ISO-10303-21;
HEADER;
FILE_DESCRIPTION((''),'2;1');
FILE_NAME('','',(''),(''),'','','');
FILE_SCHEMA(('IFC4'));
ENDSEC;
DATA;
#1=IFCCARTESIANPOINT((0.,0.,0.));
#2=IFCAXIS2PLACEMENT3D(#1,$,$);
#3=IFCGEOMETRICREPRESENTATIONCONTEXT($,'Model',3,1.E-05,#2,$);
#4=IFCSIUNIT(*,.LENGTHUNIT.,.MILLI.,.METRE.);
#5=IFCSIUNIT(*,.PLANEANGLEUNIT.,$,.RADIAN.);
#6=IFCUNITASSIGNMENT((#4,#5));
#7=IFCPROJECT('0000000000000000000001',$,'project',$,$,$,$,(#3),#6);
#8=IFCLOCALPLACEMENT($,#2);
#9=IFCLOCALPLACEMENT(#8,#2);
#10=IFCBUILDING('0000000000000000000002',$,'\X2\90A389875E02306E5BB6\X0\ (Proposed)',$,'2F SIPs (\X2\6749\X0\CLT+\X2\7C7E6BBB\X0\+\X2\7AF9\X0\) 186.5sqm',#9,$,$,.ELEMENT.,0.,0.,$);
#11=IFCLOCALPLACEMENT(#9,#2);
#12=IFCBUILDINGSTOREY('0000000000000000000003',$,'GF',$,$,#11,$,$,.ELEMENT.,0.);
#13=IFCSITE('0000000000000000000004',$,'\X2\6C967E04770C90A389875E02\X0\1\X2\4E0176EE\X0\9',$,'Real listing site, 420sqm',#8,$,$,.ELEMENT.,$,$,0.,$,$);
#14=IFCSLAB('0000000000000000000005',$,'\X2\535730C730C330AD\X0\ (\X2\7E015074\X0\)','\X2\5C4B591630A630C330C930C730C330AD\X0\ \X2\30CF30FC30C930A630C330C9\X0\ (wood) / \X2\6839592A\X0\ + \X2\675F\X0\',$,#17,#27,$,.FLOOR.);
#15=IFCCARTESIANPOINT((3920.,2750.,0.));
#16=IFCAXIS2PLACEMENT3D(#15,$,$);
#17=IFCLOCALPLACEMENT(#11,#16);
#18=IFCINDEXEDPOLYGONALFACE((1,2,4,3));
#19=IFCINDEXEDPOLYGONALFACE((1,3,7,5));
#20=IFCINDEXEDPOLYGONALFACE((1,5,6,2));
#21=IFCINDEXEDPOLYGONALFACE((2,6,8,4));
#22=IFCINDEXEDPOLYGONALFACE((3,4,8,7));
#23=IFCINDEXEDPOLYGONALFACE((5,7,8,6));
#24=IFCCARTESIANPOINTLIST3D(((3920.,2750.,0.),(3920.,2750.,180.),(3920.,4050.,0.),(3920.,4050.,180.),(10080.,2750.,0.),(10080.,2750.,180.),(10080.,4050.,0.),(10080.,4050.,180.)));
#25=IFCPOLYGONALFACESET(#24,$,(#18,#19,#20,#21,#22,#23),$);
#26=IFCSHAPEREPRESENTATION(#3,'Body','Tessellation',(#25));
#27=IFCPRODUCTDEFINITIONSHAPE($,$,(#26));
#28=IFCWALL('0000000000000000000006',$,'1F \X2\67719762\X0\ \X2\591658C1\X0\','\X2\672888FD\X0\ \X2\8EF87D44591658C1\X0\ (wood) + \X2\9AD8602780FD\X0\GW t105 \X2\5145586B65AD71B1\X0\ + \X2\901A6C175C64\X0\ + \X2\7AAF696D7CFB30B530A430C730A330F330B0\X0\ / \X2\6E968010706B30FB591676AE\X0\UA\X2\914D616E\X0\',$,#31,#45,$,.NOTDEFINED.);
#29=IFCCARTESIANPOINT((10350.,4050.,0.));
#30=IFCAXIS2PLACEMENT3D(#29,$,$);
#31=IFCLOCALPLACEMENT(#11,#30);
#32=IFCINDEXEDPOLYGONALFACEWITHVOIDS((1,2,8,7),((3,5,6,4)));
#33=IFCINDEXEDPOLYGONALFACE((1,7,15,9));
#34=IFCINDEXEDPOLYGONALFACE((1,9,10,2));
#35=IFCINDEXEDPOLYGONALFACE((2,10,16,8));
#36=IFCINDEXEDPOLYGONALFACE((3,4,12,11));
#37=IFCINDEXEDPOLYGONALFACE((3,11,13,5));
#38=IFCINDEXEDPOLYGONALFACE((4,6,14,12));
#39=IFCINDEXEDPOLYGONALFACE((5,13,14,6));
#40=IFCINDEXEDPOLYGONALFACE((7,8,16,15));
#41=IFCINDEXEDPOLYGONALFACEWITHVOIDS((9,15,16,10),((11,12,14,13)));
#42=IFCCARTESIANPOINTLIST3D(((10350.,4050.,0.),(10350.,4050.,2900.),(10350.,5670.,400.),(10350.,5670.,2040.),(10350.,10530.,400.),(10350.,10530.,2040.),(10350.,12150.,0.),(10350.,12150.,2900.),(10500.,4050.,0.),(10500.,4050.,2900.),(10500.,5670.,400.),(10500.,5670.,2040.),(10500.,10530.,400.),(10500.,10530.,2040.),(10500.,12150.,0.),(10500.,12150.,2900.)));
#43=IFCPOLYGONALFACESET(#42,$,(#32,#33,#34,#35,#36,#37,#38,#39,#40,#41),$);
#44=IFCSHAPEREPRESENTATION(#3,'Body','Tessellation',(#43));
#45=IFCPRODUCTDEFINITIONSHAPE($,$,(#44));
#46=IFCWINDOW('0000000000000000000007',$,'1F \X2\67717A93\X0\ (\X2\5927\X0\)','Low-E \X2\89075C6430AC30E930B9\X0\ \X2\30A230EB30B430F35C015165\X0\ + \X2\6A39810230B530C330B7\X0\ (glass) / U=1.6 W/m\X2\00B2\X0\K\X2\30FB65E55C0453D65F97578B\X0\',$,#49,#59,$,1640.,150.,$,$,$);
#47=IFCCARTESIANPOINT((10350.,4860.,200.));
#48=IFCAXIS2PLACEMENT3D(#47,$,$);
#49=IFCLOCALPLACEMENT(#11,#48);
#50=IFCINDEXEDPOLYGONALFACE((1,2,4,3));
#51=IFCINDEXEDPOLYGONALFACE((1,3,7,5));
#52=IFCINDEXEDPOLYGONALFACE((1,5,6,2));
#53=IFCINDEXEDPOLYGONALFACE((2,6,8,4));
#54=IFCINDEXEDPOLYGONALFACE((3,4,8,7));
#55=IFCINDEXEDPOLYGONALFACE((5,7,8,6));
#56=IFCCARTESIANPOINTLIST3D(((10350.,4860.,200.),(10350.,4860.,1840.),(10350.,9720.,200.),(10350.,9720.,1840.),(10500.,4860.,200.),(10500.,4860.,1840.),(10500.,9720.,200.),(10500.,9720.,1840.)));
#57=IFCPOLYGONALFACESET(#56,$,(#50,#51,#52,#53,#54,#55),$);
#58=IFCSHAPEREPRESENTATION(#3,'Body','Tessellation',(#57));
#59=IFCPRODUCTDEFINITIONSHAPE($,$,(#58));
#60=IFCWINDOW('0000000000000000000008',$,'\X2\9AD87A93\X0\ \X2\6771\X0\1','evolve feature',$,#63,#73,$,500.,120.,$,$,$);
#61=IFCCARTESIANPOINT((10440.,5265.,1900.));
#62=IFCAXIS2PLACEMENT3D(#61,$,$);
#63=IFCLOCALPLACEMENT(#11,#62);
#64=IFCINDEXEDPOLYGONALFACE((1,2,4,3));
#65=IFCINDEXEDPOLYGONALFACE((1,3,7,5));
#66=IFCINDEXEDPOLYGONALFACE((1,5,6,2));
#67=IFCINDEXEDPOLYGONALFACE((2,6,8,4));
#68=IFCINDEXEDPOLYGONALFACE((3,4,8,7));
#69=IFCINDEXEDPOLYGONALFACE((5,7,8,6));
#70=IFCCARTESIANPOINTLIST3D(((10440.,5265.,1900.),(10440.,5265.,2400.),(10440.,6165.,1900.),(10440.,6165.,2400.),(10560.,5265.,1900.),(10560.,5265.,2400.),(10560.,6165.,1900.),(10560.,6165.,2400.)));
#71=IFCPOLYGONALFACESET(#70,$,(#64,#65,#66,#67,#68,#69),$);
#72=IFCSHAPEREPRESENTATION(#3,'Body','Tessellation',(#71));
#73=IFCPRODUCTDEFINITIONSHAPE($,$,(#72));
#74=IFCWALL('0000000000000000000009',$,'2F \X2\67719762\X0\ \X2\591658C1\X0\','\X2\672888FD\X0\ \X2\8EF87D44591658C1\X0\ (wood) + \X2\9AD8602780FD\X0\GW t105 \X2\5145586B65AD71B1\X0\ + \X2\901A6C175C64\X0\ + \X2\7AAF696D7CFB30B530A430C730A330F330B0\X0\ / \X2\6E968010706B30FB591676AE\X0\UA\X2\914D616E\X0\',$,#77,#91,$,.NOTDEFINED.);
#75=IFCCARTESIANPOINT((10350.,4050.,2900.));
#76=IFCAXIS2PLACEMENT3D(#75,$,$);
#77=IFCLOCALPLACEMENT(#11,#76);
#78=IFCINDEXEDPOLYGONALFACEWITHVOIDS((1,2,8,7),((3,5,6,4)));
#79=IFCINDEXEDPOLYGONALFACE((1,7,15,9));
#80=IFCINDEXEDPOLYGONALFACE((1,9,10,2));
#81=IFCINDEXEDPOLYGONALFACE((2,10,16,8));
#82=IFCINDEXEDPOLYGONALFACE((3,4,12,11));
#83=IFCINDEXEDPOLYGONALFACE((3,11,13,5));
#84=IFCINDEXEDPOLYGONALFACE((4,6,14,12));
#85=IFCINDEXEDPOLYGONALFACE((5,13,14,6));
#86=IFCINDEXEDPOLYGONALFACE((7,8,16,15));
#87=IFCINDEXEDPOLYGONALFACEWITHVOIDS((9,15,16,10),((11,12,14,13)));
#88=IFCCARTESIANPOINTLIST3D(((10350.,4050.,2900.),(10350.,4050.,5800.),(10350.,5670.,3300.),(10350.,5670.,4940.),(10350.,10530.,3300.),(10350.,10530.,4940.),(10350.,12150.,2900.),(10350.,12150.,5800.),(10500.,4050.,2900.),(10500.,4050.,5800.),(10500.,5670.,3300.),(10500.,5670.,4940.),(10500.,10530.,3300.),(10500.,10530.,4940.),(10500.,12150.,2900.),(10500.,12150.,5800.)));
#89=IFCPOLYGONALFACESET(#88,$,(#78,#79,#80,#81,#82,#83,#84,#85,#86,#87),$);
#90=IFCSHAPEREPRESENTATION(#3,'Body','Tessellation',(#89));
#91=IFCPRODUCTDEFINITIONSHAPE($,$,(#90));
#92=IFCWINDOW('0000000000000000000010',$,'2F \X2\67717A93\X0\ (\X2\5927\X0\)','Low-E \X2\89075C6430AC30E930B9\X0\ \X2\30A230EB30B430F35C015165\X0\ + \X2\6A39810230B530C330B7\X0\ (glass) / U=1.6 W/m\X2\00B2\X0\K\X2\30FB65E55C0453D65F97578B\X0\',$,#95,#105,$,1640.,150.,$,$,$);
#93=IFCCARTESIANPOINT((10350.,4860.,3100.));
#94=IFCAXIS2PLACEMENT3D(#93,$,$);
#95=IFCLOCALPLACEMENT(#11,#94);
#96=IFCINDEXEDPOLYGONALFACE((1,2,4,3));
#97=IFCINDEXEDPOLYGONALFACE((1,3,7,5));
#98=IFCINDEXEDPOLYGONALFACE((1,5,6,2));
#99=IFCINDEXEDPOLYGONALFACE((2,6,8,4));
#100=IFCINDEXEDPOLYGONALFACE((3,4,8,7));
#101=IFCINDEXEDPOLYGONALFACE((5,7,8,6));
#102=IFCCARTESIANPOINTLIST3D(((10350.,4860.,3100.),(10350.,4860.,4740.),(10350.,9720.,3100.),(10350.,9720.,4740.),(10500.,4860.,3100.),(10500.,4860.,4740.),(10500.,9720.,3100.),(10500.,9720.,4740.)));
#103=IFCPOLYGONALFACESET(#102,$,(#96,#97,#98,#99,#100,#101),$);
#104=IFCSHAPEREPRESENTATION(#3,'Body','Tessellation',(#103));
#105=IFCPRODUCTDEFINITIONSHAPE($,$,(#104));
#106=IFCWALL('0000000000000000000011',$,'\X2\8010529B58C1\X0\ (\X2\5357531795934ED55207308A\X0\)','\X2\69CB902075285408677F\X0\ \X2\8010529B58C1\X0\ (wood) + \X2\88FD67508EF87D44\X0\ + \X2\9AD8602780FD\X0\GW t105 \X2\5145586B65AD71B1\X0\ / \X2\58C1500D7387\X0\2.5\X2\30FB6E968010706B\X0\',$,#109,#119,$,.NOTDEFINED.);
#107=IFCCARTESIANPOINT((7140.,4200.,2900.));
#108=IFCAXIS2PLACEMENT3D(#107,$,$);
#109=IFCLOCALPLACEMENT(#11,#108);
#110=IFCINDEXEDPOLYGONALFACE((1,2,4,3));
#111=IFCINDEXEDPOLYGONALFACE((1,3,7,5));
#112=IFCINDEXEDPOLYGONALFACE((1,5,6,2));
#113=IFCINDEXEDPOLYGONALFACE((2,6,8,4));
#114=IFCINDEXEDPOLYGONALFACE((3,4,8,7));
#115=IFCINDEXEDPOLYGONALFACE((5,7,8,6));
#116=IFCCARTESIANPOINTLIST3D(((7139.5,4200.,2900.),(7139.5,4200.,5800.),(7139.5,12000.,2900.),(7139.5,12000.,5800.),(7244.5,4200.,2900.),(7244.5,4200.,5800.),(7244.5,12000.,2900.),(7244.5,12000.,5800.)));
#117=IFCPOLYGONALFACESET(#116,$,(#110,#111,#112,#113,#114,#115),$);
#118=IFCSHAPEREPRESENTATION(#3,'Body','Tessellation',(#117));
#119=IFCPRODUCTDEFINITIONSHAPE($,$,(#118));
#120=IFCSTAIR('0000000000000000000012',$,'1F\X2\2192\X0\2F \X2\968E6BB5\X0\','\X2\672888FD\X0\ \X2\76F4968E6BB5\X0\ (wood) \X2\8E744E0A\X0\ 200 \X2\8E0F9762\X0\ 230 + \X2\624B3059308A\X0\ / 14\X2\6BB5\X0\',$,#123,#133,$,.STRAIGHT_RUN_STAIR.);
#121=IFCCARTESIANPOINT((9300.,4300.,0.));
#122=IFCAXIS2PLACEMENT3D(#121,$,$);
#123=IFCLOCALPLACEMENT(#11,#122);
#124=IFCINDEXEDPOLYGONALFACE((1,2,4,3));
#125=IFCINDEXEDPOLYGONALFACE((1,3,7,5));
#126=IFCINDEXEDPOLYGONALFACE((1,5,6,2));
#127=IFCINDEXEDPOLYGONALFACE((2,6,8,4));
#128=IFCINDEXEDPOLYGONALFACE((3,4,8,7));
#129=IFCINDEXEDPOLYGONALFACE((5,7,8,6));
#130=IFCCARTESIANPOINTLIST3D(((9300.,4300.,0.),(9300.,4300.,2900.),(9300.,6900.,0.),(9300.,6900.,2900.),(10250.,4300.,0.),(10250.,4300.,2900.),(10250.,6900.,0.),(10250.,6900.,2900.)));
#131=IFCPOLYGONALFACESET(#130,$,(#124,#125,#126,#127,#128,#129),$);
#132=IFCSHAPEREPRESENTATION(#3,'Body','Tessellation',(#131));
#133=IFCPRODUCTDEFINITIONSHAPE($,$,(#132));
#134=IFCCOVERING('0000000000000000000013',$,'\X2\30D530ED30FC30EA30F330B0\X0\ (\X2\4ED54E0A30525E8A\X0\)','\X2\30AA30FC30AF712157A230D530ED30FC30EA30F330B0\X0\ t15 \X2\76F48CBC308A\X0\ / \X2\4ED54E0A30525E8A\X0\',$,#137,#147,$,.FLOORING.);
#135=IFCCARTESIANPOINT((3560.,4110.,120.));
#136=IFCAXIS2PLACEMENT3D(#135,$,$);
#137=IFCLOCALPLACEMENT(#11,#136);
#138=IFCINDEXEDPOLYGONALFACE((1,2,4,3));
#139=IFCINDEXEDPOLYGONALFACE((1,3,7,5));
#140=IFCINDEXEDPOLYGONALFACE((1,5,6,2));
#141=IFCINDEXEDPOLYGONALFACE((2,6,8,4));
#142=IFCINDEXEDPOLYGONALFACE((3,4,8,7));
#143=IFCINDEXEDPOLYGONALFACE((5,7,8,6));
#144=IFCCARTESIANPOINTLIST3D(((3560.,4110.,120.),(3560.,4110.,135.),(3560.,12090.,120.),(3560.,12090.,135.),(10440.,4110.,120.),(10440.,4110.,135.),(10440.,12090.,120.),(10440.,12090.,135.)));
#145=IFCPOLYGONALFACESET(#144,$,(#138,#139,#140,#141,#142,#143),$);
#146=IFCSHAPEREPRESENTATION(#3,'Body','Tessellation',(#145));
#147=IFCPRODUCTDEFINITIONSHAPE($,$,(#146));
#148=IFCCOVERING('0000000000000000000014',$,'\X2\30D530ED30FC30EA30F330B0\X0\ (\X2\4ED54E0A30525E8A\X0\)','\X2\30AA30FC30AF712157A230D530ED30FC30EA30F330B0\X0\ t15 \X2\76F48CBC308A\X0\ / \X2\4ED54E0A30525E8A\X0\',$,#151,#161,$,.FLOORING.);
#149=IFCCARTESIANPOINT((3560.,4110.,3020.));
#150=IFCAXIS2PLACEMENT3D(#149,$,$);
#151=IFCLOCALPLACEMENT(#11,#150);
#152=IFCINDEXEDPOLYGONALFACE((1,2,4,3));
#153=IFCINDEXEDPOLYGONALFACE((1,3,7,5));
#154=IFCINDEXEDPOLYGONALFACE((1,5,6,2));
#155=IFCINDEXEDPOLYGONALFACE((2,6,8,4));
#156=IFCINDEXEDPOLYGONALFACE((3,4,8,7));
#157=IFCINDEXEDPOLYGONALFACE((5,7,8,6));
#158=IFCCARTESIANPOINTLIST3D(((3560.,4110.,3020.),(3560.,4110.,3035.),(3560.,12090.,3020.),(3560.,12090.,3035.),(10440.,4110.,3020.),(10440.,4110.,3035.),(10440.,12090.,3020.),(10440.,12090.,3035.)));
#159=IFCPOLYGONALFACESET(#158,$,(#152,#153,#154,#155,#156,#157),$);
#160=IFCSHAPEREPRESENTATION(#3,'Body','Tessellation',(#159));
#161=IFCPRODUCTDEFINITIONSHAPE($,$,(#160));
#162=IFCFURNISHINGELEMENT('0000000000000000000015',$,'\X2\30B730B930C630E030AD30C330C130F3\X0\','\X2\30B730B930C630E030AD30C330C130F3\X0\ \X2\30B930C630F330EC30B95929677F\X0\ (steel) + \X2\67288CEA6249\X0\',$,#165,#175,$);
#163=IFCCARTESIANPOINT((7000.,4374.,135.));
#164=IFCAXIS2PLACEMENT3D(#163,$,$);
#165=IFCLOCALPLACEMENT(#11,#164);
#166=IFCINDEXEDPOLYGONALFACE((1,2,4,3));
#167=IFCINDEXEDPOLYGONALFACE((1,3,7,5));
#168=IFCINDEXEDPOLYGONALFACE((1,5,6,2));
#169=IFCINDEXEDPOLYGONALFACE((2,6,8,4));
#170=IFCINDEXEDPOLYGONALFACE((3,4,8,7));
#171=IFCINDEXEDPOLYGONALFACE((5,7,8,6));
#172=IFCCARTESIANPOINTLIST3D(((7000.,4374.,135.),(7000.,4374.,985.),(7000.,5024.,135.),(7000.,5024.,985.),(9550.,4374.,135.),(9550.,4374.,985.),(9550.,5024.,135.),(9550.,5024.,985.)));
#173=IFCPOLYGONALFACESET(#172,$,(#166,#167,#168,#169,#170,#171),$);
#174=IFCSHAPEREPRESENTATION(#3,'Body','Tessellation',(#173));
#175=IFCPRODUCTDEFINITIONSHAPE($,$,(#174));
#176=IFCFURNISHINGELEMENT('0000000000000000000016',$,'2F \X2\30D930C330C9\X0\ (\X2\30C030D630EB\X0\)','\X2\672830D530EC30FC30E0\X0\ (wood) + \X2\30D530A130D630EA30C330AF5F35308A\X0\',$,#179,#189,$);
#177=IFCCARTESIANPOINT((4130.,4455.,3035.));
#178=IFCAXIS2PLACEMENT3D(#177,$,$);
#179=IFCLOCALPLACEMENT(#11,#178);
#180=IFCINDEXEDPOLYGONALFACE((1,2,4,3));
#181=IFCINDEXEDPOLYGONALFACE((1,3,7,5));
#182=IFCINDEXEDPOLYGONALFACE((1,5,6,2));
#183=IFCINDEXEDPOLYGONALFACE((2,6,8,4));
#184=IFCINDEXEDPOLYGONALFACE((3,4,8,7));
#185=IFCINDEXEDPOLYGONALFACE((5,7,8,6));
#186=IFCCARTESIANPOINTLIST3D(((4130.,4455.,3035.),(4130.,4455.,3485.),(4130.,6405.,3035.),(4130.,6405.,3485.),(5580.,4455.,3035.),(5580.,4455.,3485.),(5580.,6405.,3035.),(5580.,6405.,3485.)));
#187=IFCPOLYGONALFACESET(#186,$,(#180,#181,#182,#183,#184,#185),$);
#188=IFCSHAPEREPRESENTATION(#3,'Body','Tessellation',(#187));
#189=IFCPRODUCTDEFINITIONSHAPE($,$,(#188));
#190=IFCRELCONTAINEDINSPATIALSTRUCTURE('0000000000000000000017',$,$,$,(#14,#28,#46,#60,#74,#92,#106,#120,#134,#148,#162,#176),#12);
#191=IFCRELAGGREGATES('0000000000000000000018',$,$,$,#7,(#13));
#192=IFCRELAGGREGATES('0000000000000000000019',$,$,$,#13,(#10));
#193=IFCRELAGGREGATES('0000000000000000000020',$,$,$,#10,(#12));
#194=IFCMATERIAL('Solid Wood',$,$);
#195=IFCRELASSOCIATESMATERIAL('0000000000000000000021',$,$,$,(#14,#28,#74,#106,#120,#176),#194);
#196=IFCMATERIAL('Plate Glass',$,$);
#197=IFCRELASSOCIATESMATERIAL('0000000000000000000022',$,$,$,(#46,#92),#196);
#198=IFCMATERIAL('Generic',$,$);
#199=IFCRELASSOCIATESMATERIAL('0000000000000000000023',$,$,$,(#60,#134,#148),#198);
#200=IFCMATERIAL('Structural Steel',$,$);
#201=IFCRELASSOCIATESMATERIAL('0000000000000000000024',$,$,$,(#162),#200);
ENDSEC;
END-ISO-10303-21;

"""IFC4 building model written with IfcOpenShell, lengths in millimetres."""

from ifc_helpers import new_model, si_unit, frame, frame_2d, origin, place, context, project, spatial, rectangle, extrude, material, element, fill, save


model = new_model("IFC4")

# Units and contexts
model_context = context("Model", 3, precision=1e-05, world=origin())
ifc_project = project(units=[si_unit("LENGTHUNIT", "METRE", prefix="MILLI"), si_unit("PLANEANGLEUNIT", "RADIAN")], contexts=[model_context])

# Site, building, storey
site_placement = place(None, origin())
site = spatial("IfcSite", under=ifc_project, at=site_placement, Name="沖縄県那覇市1丁目9", ObjectType="Real listing site, 420sqm", CompositionType="ELEMENT", RefElevation=0.0)
building_placement = place(site_placement, origin())
building = spatial("IfcBuilding", under=site, at=building_placement, Name="那覇市の家 (Proposed)", ObjectType="2F SIPs (杉CLT+籾殻+竹) 186.5sqm", CompositionType="ELEMENT", ElevationOfRefHeight=0.0, ElevationOfTerrain=0.0)
storey_placement = place(building_placement, origin())
storey = spatial("IfcBuildingStorey", under=building, at=storey_placement, Name="GF", CompositionType="ELEMENT", Elevation=0.0)

# Slab
ifc_material_1 = material(Name="Solid Wood")
slab_placement = place(storey_placement, frame((3920.0, 2750.0, 0.0)))
element("IfcSlab", 1, at=slab_placement, inside=storey, material=ifc_material_1, Name="南デッキ (縁側)", Description="屋外ウッドデッキ ハードウッド (wood) / 根太 + 束", PredefinedType="FLOOR", context=model_context, shape_type="SweptSolid", body=[
    extrude(rectangle(XDim=6160.0, YDim=1300.0, at=frame_2d((3080.0, 650.0))), frame((3920.0, 2750.0, 0.0)), (0.0, 0.0, 1.0), 180.0),
])

# Wall, openings, windows
wall_1_placement = place(storey_placement, frame((10350.0, 4050.0, 0.0)))
wall_1 = element("IfcWall", 2, at=wall_1_placement, inside=storey, material=ifc_material_1, Name="1F 東面 外壁", Description="木製 軸組外壁 (wood) + 高性能GW t105 充填断熱 + 通気層 + 窯業系サイディング / 準耐火・外皮UA配慮", PredefinedType="NOTDEFINED", context=model_context, shape_type="SweptSolid", body=[
    extrude(rectangle(XDim=150.0, YDim=8100.0, at=frame_2d((75.0, 4050.0))), frame((10350.0, 4050.0, 0.0)), (0.0, 0.0, 1.0), 2900.0),
])
opening_1_placement = place(storey_placement, frame((10350.0, 4860.0, 200.0)))
opening_1 = element("IfcOpeningElement", 3, at=opening_1_placement, cuts=wall_1, PredefinedType="NOTDEFINED", context=model_context, shape_type="SweptSolid", body=[
    extrude(rectangle(XDim=150.0, YDim=4860.0, at=frame_2d((75.0, 2430.0))), frame((10350.0, 4860.0, 200.0)), (0.0, 0.0, 1.0), 1640.0),
])
opening_2_placement = place(storey_placement, frame((10440.0, 5265.0, 1900.0)))
opening_2 = element("IfcOpeningElement", 4, at=opening_2_placement, cuts=wall_1, PredefinedType="NOTDEFINED", context=model_context, shape_type="SweptSolid", body=[
    extrude(rectangle(XDim=120.0, YDim=900.0, at=frame_2d((60.0, 450.0))), frame((10440.0, 5265.0, 1900.0)), (0.0, 0.0, 1.0), 500.0),
])
ifc_material_2 = material(Name="Plate Glass")
window_1_placement = place(storey_placement, frame((10350.0, 4860.0, 200.0)))
window_1 = element("IfcWindow", 5, at=window_1_placement, inside=storey, material=ifc_material_2, Name="1F 東窓 (大)", Description="Low-E 複層ガラス アルゴン封入 + 樹脂サッシ (glass) / U=1.6 W/m²K・日射取得型", OverallHeight=1640.0, OverallWidth=150.0, context=model_context, shape_type="SweptSolid", body=[
    extrude(rectangle(XDim=150.0, YDim=4860.0, at=frame_2d((75.0, 2430.0))), frame((10350.0, 4860.0, 200.0)), (0.0, 0.0, 1.0), 1640.0),
])
fill(opening_1, window_1)
ifc_material_3 = material(Name="Generic")
window_2_placement = place(storey_placement, frame((10440.0, 5265.0, 1900.0)))
window_2 = element("IfcWindow", 6, at=window_2_placement, inside=storey, material=ifc_material_3, Name="高窓 東1", Description="evolve feature", OverallHeight=500.0, OverallWidth=120.0, context=model_context, shape_type="SweptSolid", body=[
    extrude(rectangle(XDim=120.0, YDim=900.0, at=frame_2d((60.0, 450.0))), frame((10440.0, 5265.0, 1900.0)), (0.0, 0.0, 1.0), 500.0),
])
fill(opening_2, window_2)

# Wall, opening, window
wall_2_placement = place(storey_placement, frame((10350.0, 4050.0, 2900.0)))
wall_2 = element("IfcWall", 7, at=wall_2_placement, inside=storey, material=ifc_material_1, Name="2F 東面 外壁", Description="木製 軸組外壁 (wood) + 高性能GW t105 充填断熱 + 通気層 + 窯業系サイディング / 準耐火・外皮UA配慮", PredefinedType="NOTDEFINED", context=model_context, shape_type="SweptSolid", body=[
    extrude(rectangle(XDim=150.0, YDim=8100.0, at=frame_2d((75.0, 4050.0))), frame((10350.0, 4050.0, 2900.0)), (0.0, 0.0, 1.0), 2900.0),
])
opening_3_placement = place(storey_placement, frame((10350.0, 4860.0, 3100.0)))
opening_3 = element("IfcOpeningElement", 8, at=opening_3_placement, cuts=wall_2, PredefinedType="NOTDEFINED", context=model_context, shape_type="SweptSolid", body=[
    extrude(rectangle(XDim=150.0, YDim=4860.0, at=frame_2d((75.0, 2430.0))), frame((10350.0, 4860.0, 3100.0)), (0.0, 0.0, 1.0), 1640.0),
])
window_3_placement = place(storey_placement, frame((10350.0, 4860.0, 3100.0)))
window_3 = element("IfcWindow", 9, at=window_3_placement, inside=storey, material=ifc_material_2, Name="2F 東窓 (大)", Description="Low-E 複層ガラス アルゴン封入 + 樹脂サッシ (glass) / U=1.6 W/m²K・日射取得型", OverallHeight=1640.0, OverallWidth=150.0, context=model_context, shape_type="SweptSolid", body=[
    extrude(rectangle(XDim=150.0, YDim=4860.0, at=frame_2d((75.0, 2430.0))), frame((10350.0, 4860.0, 3100.0)), (0.0, 0.0, 1.0), 1640.0),
])
fill(opening_3, window_3)

# Wall
wall_3_placement = place(storey_placement, frame((7140.0, 4200.0, 2900.0)))
element("IfcWall", 10, at=wall_3_placement, inside=storey, material=ifc_material_1, Name="耐力壁 (南北間仕切り)", Description="構造用合板 耐力壁 (wood) + 製材軸組 + 高性能GW t105 充填断熱 / 壁倍率2.5・準耐火", PredefinedType="NOTDEFINED", context=model_context, shape_type="SweptSolid", body=[
    extrude(rectangle(XDim=105.0, YDim=7800.0, at=frame_2d((52.0, 3900.0))), frame((7140.0, 4200.0, 2900.0)), (0.0, 0.0, 1.0), 2900.0),
])

# Stair
stair_placement = place(storey_placement, frame((9300.0, 4300.0, 0.0)))
element("IfcStair", 11, at=stair_placement, inside=storey, material=ifc_material_1, Name="1F→2F 階段", Description="木製 直階段 (wood) 蹴上 200 踏面 230 + 手すり / 14段", PredefinedType="STRAIGHT_RUN_STAIR", context=model_context, shape_type="SweptSolid", body=[
    extrude(rectangle(XDim=950.0, YDim=2600.0, at=frame_2d((475.0, 1300.0))), frame((9300.0, 4300.0, 0.0)), (0.0, 0.0, 1.0), 2900.0),
])

# Coverings
covering_1_placement = place(storey_placement, frame((3560.0, 4110.0, 120.0)))
element("IfcCovering", 12, at=covering_1_placement, inside=storey, material=ifc_material_3, Name="フローリング (仕上げ床)", Description="オーク無垢フローリング t15 直貼り / 仕上げ床", PredefinedType="FLOORING", context=model_context, shape_type="SweptSolid", body=[
    extrude(rectangle(XDim=6880.0, YDim=7980.0, at=frame_2d((3440.0, 3990.0))), frame((3560.0, 4110.0, 120.0)), (0.0, 0.0, 1.0), 15.0),
])
covering_2_placement = place(storey_placement, frame((3560.0, 4110.0, 3020.0)))
element("IfcCovering", 13, at=covering_2_placement, inside=storey, material=ifc_material_3, Name="フローリング (仕上げ床)", Description="オーク無垢フローリング t15 直貼り / 仕上げ床", PredefinedType="FLOORING", context=model_context, shape_type="SweptSolid", body=[
    extrude(rectangle(XDim=6880.0, YDim=7980.0, at=frame_2d((3440.0, 3990.0))), frame((3560.0, 4110.0, 3020.0)), (0.0, 0.0, 1.0), 15.0),
])

# Furnishing elements
ifc_material_4 = material(Name="Structural Steel")
furnishing_1_placement = place(storey_placement, frame((7000.0, 4374.0, 135.0)))
element("IfcFurnishingElement", 14, at=furnishing_1_placement, inside=storey, material=ifc_material_4, Name="システムキッチン", Description="システムキッチン ステンレス天板 (steel) + 木質扉", context=model_context, shape_type="SweptSolid", body=[
    extrude(rectangle(XDim=2550.0, YDim=650.0, at=frame_2d((1275.0, 325.0))), frame((7000.0, 4374.0, 135.0)), (0.0, 0.0, 1.0), 850.0),
])
furnishing_2_placement = place(storey_placement, frame((4130.0, 4455.0, 3035.0)))
element("IfcFurnishingElement", 15, at=furnishing_2_placement, inside=storey, material=ifc_material_1, Name="2F ベッド (ダブル)", Description="木フレーム (wood) + ファブリック張り", context=model_context, shape_type="SweptSolid", body=[
    extrude(rectangle(XDim=1450.0, YDim=1950.0, at=frame_2d((725.0, 975.0))), frame((4130.0, 4455.0, 3035.0)), (0.0, 0.0, 1.0), 450.0),
])

save(model, "model.ifc")
